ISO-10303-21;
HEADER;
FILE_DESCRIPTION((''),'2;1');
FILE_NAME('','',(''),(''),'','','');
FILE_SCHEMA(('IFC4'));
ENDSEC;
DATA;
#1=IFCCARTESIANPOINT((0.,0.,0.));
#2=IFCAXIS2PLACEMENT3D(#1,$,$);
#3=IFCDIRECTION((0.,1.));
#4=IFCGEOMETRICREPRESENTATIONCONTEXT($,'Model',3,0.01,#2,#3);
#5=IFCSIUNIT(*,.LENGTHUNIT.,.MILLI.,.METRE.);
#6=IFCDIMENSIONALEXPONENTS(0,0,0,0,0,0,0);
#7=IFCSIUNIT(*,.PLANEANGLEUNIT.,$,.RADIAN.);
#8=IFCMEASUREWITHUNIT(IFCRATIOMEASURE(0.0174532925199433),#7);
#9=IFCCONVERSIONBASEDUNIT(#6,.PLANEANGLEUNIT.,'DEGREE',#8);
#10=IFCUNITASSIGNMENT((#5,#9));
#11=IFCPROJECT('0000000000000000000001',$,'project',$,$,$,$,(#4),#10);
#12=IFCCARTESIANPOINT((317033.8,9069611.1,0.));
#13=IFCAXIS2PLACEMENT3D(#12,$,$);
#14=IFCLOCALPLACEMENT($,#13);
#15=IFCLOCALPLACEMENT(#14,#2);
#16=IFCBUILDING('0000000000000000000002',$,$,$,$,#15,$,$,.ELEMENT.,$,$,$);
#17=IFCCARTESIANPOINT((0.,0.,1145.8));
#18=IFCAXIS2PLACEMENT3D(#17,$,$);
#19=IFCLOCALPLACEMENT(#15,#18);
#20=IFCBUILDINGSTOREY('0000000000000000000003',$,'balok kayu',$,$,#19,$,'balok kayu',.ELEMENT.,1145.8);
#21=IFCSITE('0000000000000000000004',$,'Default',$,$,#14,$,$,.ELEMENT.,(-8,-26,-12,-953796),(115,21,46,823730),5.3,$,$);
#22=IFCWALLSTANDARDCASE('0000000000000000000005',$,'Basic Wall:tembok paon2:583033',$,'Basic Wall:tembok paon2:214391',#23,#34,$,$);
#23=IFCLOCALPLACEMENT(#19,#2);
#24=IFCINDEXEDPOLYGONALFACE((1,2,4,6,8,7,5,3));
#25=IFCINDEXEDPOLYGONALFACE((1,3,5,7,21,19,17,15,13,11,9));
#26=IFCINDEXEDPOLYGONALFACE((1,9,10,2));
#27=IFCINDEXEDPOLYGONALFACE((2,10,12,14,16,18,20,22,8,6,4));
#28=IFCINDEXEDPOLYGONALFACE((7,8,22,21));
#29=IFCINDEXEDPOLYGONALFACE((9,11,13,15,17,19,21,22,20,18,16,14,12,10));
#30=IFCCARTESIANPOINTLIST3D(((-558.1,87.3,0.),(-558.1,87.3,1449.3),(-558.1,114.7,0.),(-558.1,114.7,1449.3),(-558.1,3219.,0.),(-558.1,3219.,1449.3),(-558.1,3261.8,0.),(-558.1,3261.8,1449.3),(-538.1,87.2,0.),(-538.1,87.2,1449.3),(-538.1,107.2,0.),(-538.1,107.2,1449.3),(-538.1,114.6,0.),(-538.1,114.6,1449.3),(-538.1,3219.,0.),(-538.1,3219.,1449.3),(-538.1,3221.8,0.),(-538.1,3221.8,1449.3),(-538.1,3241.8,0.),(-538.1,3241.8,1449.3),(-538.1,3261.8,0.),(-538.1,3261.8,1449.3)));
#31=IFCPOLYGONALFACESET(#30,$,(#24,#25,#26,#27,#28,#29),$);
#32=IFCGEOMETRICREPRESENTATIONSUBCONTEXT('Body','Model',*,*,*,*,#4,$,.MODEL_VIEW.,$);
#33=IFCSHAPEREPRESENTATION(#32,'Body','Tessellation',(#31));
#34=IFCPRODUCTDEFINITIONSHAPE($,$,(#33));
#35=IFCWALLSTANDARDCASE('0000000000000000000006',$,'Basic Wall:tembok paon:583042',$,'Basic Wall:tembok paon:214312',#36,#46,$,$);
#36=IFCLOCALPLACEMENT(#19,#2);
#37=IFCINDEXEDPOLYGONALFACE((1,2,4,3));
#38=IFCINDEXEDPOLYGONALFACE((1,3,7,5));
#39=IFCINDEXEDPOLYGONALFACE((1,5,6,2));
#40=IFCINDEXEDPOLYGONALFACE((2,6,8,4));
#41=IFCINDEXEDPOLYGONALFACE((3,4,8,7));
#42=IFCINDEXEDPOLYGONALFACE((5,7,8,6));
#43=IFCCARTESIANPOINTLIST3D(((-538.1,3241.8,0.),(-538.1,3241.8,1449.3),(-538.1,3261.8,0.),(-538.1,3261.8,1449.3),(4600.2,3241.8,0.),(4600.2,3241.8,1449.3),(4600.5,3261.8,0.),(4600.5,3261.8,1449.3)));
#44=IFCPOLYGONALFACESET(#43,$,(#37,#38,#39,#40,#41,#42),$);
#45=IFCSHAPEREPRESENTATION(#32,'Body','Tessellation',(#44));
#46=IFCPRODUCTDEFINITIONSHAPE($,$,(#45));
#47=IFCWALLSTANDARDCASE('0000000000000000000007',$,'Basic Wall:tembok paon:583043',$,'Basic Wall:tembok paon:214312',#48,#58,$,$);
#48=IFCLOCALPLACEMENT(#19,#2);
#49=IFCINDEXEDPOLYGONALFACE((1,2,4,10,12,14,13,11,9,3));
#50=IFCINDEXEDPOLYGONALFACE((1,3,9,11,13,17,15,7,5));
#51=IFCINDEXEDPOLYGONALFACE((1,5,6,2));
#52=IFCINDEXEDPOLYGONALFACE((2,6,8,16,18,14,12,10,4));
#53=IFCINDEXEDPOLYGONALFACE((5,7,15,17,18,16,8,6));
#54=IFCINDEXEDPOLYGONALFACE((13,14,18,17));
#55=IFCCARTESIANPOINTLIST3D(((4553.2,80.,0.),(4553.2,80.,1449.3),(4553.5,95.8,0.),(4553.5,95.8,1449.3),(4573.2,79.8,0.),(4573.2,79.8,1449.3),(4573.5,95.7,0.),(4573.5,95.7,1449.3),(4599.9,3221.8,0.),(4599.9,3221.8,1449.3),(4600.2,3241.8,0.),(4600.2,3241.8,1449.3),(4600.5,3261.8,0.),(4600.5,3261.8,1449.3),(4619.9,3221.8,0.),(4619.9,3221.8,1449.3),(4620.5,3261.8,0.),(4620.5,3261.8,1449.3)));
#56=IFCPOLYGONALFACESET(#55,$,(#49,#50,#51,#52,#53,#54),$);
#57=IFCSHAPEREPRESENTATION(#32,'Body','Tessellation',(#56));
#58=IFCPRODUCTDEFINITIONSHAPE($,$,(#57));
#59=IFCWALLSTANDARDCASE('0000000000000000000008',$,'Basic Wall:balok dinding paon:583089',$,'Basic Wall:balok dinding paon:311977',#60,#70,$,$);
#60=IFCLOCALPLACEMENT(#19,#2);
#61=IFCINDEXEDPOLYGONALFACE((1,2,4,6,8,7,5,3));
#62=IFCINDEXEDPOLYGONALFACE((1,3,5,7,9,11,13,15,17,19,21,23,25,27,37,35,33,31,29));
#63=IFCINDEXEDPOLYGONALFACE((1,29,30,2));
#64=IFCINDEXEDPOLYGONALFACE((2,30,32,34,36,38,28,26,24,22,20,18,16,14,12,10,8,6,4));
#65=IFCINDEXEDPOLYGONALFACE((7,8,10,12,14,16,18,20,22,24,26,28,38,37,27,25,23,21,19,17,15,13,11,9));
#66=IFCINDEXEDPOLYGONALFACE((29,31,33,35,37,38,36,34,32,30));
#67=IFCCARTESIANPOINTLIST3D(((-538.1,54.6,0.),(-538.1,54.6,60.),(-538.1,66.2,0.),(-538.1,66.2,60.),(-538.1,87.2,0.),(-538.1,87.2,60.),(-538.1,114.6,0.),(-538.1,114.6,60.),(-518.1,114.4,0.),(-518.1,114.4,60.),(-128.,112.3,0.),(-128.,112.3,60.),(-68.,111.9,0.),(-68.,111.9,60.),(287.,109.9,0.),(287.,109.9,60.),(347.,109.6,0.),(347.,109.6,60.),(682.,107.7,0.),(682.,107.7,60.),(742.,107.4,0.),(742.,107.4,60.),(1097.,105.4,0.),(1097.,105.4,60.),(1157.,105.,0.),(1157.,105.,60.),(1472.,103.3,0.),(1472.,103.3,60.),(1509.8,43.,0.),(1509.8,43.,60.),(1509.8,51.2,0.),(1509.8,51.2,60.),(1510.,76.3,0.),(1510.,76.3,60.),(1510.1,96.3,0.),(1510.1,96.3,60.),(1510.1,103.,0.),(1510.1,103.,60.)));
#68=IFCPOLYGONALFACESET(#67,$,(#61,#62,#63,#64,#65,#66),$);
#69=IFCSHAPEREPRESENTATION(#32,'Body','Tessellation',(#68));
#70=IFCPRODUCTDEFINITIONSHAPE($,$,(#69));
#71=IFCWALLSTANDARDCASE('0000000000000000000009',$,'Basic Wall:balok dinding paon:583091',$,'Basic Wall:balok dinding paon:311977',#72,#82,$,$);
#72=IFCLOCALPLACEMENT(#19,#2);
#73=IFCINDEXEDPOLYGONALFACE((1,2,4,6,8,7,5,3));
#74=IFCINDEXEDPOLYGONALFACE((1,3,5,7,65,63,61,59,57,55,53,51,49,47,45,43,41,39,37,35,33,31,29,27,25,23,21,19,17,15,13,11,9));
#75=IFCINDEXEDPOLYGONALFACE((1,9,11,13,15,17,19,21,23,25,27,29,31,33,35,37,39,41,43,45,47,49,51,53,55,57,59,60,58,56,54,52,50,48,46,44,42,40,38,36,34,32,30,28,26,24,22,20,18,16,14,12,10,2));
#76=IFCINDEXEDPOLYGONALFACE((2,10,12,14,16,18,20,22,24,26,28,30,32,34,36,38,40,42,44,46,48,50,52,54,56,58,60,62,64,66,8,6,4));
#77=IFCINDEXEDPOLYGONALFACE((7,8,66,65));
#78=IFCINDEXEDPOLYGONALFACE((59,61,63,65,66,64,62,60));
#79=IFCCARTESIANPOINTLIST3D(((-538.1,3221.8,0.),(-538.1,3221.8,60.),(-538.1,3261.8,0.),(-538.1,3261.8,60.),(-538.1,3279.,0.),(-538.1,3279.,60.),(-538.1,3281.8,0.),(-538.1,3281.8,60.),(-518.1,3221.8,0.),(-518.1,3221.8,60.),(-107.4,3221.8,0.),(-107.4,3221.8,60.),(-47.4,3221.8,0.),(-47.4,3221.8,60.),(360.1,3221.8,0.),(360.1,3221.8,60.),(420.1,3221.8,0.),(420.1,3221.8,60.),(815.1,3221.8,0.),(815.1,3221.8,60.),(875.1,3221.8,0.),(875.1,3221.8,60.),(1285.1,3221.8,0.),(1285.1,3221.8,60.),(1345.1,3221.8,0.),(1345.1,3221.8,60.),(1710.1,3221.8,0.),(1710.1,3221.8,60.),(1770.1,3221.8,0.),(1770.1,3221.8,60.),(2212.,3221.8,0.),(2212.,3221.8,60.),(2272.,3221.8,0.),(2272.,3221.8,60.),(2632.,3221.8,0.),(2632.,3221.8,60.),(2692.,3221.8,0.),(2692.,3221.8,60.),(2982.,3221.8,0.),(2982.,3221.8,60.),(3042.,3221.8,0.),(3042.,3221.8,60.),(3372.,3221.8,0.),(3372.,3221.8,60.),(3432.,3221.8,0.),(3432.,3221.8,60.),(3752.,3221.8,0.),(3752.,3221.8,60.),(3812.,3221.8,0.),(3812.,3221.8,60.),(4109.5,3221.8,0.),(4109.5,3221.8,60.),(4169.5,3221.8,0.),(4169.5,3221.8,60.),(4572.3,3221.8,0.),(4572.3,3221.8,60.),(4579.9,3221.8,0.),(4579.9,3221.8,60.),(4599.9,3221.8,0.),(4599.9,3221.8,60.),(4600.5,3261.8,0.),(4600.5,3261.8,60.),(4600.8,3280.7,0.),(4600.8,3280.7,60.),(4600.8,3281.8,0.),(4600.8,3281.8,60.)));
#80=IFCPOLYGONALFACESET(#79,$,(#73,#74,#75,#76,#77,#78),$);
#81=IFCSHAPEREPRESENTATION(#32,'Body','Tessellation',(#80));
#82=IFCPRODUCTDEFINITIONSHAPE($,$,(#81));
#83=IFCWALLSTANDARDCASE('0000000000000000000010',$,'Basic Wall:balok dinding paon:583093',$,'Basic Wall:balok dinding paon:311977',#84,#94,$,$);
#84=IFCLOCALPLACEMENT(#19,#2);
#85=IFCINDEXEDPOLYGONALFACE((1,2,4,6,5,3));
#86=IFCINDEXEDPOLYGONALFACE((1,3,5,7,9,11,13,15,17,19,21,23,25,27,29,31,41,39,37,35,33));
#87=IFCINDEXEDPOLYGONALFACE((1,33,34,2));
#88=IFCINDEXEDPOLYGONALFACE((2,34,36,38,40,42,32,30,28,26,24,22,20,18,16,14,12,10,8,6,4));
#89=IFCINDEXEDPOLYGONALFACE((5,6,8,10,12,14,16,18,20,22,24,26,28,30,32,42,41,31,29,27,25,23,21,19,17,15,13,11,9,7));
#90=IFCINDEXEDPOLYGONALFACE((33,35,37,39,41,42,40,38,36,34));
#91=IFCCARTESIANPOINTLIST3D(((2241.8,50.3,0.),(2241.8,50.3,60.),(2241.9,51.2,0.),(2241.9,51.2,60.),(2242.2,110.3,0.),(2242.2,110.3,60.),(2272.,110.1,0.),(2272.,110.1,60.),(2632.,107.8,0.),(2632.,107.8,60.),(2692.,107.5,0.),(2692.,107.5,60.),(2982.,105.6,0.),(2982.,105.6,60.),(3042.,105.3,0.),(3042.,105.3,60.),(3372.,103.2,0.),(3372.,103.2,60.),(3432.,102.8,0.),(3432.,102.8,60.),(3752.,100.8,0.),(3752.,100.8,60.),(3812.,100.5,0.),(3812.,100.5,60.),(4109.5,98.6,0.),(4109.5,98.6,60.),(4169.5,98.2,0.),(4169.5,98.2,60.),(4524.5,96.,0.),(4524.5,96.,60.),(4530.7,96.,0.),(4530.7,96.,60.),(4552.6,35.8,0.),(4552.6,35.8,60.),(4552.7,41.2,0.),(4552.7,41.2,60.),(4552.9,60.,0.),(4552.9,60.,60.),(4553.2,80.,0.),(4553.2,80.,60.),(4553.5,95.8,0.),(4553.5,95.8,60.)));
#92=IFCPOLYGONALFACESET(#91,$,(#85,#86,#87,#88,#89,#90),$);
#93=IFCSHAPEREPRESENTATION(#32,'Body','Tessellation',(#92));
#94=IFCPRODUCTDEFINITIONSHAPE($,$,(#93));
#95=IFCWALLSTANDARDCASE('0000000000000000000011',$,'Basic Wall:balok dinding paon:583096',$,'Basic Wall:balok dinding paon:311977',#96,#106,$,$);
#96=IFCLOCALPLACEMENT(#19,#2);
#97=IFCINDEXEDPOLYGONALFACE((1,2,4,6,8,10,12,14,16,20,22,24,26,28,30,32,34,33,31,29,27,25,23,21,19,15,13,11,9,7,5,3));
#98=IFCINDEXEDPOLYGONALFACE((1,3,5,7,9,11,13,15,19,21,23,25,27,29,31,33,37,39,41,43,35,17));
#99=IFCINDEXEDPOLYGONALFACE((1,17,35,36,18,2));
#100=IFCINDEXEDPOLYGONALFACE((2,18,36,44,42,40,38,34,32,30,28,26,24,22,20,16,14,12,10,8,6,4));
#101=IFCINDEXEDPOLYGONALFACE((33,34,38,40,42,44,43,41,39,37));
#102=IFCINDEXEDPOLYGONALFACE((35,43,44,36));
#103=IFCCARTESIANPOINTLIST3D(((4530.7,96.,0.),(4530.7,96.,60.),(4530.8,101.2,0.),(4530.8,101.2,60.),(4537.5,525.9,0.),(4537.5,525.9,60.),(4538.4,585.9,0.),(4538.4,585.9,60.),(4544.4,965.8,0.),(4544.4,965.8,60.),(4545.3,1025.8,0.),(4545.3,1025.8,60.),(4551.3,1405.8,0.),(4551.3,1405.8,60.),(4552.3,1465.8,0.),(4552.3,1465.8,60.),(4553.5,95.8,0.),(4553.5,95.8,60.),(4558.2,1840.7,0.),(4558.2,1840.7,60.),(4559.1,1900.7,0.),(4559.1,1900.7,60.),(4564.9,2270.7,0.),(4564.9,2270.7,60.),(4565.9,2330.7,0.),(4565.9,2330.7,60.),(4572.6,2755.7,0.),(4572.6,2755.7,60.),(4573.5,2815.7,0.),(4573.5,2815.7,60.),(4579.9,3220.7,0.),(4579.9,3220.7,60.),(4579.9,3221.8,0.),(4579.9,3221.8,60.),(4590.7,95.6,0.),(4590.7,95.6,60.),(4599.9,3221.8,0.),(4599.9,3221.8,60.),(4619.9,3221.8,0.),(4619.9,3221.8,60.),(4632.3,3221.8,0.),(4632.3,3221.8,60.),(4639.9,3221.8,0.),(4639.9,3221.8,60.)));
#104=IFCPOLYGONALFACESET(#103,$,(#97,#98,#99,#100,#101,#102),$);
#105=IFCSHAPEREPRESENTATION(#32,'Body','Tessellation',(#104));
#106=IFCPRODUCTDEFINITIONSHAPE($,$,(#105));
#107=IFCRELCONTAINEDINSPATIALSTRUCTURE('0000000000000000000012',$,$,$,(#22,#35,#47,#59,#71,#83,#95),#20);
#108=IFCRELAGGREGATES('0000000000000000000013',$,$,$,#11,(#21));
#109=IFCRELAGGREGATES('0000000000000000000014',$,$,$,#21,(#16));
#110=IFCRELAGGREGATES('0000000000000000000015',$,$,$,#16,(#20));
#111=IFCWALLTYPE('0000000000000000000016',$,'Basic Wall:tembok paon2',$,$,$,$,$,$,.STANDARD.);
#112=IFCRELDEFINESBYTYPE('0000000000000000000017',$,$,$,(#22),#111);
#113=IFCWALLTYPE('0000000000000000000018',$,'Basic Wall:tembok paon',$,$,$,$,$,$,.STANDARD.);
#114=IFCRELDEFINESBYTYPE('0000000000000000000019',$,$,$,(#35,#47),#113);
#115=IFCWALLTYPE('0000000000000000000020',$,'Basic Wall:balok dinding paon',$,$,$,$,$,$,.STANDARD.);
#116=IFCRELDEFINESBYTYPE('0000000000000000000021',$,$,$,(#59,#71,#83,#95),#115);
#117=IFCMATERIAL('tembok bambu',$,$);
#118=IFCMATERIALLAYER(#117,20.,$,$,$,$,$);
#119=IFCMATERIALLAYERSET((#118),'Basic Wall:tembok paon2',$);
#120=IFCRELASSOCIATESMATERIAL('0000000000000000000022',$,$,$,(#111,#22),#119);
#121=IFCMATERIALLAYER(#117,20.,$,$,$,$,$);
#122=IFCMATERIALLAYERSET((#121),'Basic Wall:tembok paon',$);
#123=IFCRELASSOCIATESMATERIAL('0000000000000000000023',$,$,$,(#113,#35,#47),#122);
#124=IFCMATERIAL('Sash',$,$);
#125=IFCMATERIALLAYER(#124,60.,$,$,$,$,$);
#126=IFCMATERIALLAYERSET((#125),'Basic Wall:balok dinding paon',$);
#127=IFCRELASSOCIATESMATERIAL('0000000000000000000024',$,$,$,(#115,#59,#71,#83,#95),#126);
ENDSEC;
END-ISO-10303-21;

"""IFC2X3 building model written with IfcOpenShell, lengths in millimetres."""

from ifc_helpers import new_model, entity, si_unit, converted_unit, direction, frame, origin, place, context, subcontext, project, spatial, polyline, outline, extrude, material, layer, layer_set, layer_usage, type_object, element, save


model = new_model("IFC2X3")

# Units and contexts
model_context = context("Model", 3, precision=0.01, world=origin(), true_north=direction((0.0, 1.0)))
body_context = subcontext(model_context, "Body", "Model", "MODEL_VIEW")
ifc_project = project(units=[si_unit("LENGTHUNIT", "METRE", prefix="MILLI"), converted_unit("PLANEANGLEUNIT", "DEGREE", entity("IfcRatioMeasure", 0.0174532925199433), si_unit("PLANEANGLEUNIT", "RADIAN"), dimensions=[0, 0, 0, 0, 0, 0, 0])], contexts=[model_context])

# Site, building, storey
site_placement = place(None, frame((317033.8, 9069611.1, 0.0)))
site = spatial("IfcSite", under=ifc_project, at=site_placement, Name="Default", CompositionType="ELEMENT", RefLatitude=(-8, -26, -12, -953796), RefLongitude=(115, 21, 46, 823730), RefElevation=5.3)
building_placement = place(site_placement, origin())
building = spatial("IfcBuilding", under=site, at=building_placement, CompositionType="ELEMENT")
storey_placement = place(building_placement, frame((0.0, 0.0, 1145.8)))
storey = spatial("IfcBuildingStorey", under=building, at=storey_placement, Name="balok kayu", LongName="balok kayu", CompositionType="ELEMENT", Elevation=1145.8)

# Walls
ifc_material_1 = material(Name="tembok bambu")
ifc_layer_1 = layer(ifc_material_1, 20.0)
ifc_layer_set_1 = layer_set([ifc_layer_1], Name="Basic Wall:tembok paon2")
ifc_layer_usage_1 = layer_usage(ifc_layer_set_1, "AXIS2", "NEGATIVE", 10.0)
wall_type_1 = type_object("IfcWallType", Name="Basic Wall:tembok paon2", PredefinedType="STANDARD", material=ifc_layer_set_1)
wall_1_placement = place(storey_placement, frame((-548.1, 3261.8, 0.0), z_axis=(0.0, 0.0, 1.0), x_axis=(0.0, -1.0, 0.0)))
element("IfcWallStandardCase", 1, at=wall_1_placement, inside=storey, type_object=wall_type_1, material=ifc_layer_usage_1, Name="Basic Wall:tembok paon2:583033", ObjectType="Basic Wall:tembok paon2:214391", context=body_context, shape_type="SweptSolid", body=[
    extrude(outline(polyline([(3174.5, -10.0), (3174.6, 10.0), (3154.6, 10.0), (3147.2, 10.0), (42.8, 10.0), (40.0, 10.0), (20.0, 10.0), (0.0, 10.0), (0.0, -10.0), (42.8, -10.0), (3147.1, -10.0), (3174.5, -10.0)])), origin(), (0.0, 0.0, 1.0), 1449.3),
])
ifc_layer_2 = layer(ifc_material_1, 20.0)
ifc_layer_set_2 = layer_set([ifc_layer_2], Name="Basic Wall:tembok paon")
ifc_layer_usage_2 = layer_usage(ifc_layer_set_2, "AXIS2", "NEGATIVE", 10.0)
wall_type_2 = type_object("IfcWallType", Name="Basic Wall:tembok paon", PredefinedType="STANDARD", material=ifc_layer_set_2)
wall_2_placement = place(storey_placement, frame((-538.1, 3251.8, 0.0)))
element("IfcWallStandardCase", 2, at=wall_2_placement, inside=storey, type_object=wall_type_2, material=ifc_layer_usage_2, Name="Basic Wall:tembok paon:583042", ObjectType="Basic Wall:tembok paon:214312", context=body_context, shape_type="SweptSolid", body=[
    extrude(outline(polyline([(5138.3, -10.0), (5138.6, 10.0), (0.0, 10.0), (0.0, -10.0), (5138.3, -10.0)])), origin(), (0.0, 0.0, 1.0), 1449.3),
])
ifc_layer_usage_3 = layer_usage(ifc_layer_set_2, "AXIS2", "NEGATIVE", 10.0)
wall_3_placement = place(storey_placement, frame((4610.5, 3262.0, 0.0), z_axis=(0.0, 0.0, 1.0), x_axis=(-0.014861, -0.99989, 0.0)))
element("IfcWallStandardCase", 3, at=wall_3_placement, inside=storey, type_object=wall_type_2, material=ifc_layer_usage_3, Name="Basic Wall:tembok paon:583043", ObjectType="Basic Wall:tembok paon:214312", context=body_context, shape_type="SweptSolid", body=[
    extrude(outline(polyline([(3182.5, -10.0), (3182.3, 10.0), (3166.5, 10.0), (40.0, 10.0), (0.0, 10.0), (0.3, -10.0), (20.3, -10.0), (40.3, -10.0), (3166.6, -10.0), (3182.5, -10.0)])), origin(), (0.0, 0.0, 1.0), 1449.3),
])

# Walls
ifc_material_2 = material(Name="Sash")
ifc_layer_3 = layer(ifc_material_2, 60.0)
ifc_layer_set_3 = layer_set([ifc_layer_3], Name="Basic Wall:balok dinding paon")
ifc_layer_usage_4 = layer_usage(ifc_layer_set_3, "AXIS2", "NEGATIVE", 30.0)
wall_type_3 = type_object("IfcWallType", Name="Basic Wall:balok dinding paon", PredefinedType="STANDARD", material=ifc_layer_set_3)
wall_4_placement = place(storey_placement, frame((-538.3, 84.6, 0.0), z_axis=(0.0, 0.0, 1.0), x_axis=(0.999984, -0.005623, 0.0)))
element("IfcWallStandardCase", 4, at=wall_4_placement, inside=storey, type_object=wall_type_3, material=ifc_layer_usage_4, Name="Basic Wall:balok dinding paon:583089", ObjectType="Basic Wall:balok dinding paon:311977", context=body_context, shape_type="SweptSolid", body=[
    extrude(outline(polyline([(2048.2, -30.0), (2048.2, -21.9), (2048.2, 3.2), (2048.2, 23.2), (2048.2, 30.0), (2010.2, 30.0), (1695.2, 30.0), (1635.1, 30.0), (1280.1, 30.0), (1220.1, 30.0), (885.1, 30.0), (825.1, 30.0), (470.1, 30.0), (410.1, 30.0), (20.0, 30.0), (0.0, 30.0), (0.2, 2.7), (0.3, -18.4), (0.3, -30.0), (2048.2, -30.0)])), origin(), (0.0, 0.0, 1.0), 60.0),
])
ifc_layer_usage_5 = layer_usage(ifc_layer_set_3, "AXIS2", "NEGATIVE", 30.0)
wall_5_placement = place(storey_placement, frame((-538.1, 3251.8, 0.0)))
element("IfcWallStandardCase", 5, at=wall_5_placement, inside=storey, type_object=wall_type_3, material=ifc_layer_usage_5, Name="Basic Wall:balok dinding paon:583091", ObjectType="Basic Wall:balok dinding paon:311977", context=body_context, shape_type="SweptSolid", body=[
    extrude(outline(polyline([(5138.0, -30.0), (5138.6, 10.0), (5138.9, 28.9), (5138.9, 30.0), (0.0, 30.0), (0.0, 27.2), (0.0, 10.0), (0.0, -30.0), (20.0, -30.0), (430.7, -30.0), (490.7, -30.0), (898.2, -30.0), (958.2, -30.0), (1353.2, -30.0), (1413.2, -30.0), (1823.2, -30.0), (1883.2, -30.0), (2248.2, -30.0), (2308.2, -30.0), (2750.1, -30.0), (2810.1, -30.0), (3170.1, -30.0), (3230.1, -30.0), (3520.1, -30.0), (3580.1, -30.0), (3910.1, -30.0), (3970.1, -30.0), (4290.1, -30.0), (4350.1, -30.0), (4647.6, -30.0), (4707.6, -30.0), (5110.4, -30.0), (5118.0, -30.0), (5138.0, -30.0)])), origin(), (0.0, 0.0, 1.0), 60.0),
])
ifc_layer_usage_6 = layer_usage(ifc_layer_set_3, "AXIS2", "NEGATIVE", 30.0)
wall_6_placement = place(storey_placement, frame((2242.0, 80.3, 0.0), z_axis=(0.0, 0.0, 1.0), x_axis=(0.99998, -0.006246, 0.0)))
element("IfcWallStandardCase", 6, at=wall_6_placement, inside=storey, type_object=wall_type_3, material=ifc_layer_usage_6, Name="Basic Wall:balok dinding paon:583093", ObjectType="Basic Wall:balok dinding paon:311977", context=body_context, shape_type="SweptSolid", body=[
    extrude(outline(polyline([(2310.8, -30.0), (2310.8, -24.7), (2311.0, -5.9), (2311.2, 14.1), (2311.3, 30.0), (2288.5, 30.0), (2282.4, 30.0), (1927.4, 30.0), (1867.3, 30.0), (1569.8, 30.0), (1509.8, 30.0), (1189.8, 30.0), (1129.8, 30.0), (799.8, 30.0), (739.8, 30.0), (449.8, 30.0), (389.8, 30.0), (29.8, 30.0), (0.0, 30.0), (0.0, -29.1), (0.0, -30.0), (2310.8, -30.0)])), origin(), (0.0, 0.0, 1.0), 60.0),
])
ifc_layer_usage_7 = layer_usage(ifc_layer_set_3, "AXIS2", "NEGATIVE", 30.0)
wall_7_placement = place(storey_placement, frame((4609.9, 3222.3, 0.0), z_axis=(0.0, 0.0, 1.0), x_axis=(-0.015744, -0.999876, 0.0)))
element("IfcWallStandardCase", 7, at=wall_7_placement, inside=storey, type_object=wall_type_3, material=ifc_layer_usage_7, Name="Basic Wall:balok dinding paon:583096", ObjectType="Basic Wall:balok dinding paon:311977", context=body_context, shape_type="SweptSolid", body=[
    extrude(outline(polyline([(3127.2, -30.0), (3127.0, -7.2), (3126.6, 30.0), (0.0, 30.0), (0.1, 22.4), (0.3, 10.0), (0.6, -10.0), (0.9, -30.0), (2.0, -30.0), (407.1, -30.0), (467.1, -30.0), (892.1, -30.0), (952.1, -30.0), (1322.2, -30.0), (1382.2, -30.0), (1757.1, -30.0), (1817.2, -30.0), (2197.2, -30.0), (2257.2, -30.0), (2637.2, -30.0), (2697.2, -30.0), (3122.0, -30.0), (3127.2, -30.0)])), origin(), (0.0, 0.0, 1.0), 60.0),
])

save(model, "model.ifc")
